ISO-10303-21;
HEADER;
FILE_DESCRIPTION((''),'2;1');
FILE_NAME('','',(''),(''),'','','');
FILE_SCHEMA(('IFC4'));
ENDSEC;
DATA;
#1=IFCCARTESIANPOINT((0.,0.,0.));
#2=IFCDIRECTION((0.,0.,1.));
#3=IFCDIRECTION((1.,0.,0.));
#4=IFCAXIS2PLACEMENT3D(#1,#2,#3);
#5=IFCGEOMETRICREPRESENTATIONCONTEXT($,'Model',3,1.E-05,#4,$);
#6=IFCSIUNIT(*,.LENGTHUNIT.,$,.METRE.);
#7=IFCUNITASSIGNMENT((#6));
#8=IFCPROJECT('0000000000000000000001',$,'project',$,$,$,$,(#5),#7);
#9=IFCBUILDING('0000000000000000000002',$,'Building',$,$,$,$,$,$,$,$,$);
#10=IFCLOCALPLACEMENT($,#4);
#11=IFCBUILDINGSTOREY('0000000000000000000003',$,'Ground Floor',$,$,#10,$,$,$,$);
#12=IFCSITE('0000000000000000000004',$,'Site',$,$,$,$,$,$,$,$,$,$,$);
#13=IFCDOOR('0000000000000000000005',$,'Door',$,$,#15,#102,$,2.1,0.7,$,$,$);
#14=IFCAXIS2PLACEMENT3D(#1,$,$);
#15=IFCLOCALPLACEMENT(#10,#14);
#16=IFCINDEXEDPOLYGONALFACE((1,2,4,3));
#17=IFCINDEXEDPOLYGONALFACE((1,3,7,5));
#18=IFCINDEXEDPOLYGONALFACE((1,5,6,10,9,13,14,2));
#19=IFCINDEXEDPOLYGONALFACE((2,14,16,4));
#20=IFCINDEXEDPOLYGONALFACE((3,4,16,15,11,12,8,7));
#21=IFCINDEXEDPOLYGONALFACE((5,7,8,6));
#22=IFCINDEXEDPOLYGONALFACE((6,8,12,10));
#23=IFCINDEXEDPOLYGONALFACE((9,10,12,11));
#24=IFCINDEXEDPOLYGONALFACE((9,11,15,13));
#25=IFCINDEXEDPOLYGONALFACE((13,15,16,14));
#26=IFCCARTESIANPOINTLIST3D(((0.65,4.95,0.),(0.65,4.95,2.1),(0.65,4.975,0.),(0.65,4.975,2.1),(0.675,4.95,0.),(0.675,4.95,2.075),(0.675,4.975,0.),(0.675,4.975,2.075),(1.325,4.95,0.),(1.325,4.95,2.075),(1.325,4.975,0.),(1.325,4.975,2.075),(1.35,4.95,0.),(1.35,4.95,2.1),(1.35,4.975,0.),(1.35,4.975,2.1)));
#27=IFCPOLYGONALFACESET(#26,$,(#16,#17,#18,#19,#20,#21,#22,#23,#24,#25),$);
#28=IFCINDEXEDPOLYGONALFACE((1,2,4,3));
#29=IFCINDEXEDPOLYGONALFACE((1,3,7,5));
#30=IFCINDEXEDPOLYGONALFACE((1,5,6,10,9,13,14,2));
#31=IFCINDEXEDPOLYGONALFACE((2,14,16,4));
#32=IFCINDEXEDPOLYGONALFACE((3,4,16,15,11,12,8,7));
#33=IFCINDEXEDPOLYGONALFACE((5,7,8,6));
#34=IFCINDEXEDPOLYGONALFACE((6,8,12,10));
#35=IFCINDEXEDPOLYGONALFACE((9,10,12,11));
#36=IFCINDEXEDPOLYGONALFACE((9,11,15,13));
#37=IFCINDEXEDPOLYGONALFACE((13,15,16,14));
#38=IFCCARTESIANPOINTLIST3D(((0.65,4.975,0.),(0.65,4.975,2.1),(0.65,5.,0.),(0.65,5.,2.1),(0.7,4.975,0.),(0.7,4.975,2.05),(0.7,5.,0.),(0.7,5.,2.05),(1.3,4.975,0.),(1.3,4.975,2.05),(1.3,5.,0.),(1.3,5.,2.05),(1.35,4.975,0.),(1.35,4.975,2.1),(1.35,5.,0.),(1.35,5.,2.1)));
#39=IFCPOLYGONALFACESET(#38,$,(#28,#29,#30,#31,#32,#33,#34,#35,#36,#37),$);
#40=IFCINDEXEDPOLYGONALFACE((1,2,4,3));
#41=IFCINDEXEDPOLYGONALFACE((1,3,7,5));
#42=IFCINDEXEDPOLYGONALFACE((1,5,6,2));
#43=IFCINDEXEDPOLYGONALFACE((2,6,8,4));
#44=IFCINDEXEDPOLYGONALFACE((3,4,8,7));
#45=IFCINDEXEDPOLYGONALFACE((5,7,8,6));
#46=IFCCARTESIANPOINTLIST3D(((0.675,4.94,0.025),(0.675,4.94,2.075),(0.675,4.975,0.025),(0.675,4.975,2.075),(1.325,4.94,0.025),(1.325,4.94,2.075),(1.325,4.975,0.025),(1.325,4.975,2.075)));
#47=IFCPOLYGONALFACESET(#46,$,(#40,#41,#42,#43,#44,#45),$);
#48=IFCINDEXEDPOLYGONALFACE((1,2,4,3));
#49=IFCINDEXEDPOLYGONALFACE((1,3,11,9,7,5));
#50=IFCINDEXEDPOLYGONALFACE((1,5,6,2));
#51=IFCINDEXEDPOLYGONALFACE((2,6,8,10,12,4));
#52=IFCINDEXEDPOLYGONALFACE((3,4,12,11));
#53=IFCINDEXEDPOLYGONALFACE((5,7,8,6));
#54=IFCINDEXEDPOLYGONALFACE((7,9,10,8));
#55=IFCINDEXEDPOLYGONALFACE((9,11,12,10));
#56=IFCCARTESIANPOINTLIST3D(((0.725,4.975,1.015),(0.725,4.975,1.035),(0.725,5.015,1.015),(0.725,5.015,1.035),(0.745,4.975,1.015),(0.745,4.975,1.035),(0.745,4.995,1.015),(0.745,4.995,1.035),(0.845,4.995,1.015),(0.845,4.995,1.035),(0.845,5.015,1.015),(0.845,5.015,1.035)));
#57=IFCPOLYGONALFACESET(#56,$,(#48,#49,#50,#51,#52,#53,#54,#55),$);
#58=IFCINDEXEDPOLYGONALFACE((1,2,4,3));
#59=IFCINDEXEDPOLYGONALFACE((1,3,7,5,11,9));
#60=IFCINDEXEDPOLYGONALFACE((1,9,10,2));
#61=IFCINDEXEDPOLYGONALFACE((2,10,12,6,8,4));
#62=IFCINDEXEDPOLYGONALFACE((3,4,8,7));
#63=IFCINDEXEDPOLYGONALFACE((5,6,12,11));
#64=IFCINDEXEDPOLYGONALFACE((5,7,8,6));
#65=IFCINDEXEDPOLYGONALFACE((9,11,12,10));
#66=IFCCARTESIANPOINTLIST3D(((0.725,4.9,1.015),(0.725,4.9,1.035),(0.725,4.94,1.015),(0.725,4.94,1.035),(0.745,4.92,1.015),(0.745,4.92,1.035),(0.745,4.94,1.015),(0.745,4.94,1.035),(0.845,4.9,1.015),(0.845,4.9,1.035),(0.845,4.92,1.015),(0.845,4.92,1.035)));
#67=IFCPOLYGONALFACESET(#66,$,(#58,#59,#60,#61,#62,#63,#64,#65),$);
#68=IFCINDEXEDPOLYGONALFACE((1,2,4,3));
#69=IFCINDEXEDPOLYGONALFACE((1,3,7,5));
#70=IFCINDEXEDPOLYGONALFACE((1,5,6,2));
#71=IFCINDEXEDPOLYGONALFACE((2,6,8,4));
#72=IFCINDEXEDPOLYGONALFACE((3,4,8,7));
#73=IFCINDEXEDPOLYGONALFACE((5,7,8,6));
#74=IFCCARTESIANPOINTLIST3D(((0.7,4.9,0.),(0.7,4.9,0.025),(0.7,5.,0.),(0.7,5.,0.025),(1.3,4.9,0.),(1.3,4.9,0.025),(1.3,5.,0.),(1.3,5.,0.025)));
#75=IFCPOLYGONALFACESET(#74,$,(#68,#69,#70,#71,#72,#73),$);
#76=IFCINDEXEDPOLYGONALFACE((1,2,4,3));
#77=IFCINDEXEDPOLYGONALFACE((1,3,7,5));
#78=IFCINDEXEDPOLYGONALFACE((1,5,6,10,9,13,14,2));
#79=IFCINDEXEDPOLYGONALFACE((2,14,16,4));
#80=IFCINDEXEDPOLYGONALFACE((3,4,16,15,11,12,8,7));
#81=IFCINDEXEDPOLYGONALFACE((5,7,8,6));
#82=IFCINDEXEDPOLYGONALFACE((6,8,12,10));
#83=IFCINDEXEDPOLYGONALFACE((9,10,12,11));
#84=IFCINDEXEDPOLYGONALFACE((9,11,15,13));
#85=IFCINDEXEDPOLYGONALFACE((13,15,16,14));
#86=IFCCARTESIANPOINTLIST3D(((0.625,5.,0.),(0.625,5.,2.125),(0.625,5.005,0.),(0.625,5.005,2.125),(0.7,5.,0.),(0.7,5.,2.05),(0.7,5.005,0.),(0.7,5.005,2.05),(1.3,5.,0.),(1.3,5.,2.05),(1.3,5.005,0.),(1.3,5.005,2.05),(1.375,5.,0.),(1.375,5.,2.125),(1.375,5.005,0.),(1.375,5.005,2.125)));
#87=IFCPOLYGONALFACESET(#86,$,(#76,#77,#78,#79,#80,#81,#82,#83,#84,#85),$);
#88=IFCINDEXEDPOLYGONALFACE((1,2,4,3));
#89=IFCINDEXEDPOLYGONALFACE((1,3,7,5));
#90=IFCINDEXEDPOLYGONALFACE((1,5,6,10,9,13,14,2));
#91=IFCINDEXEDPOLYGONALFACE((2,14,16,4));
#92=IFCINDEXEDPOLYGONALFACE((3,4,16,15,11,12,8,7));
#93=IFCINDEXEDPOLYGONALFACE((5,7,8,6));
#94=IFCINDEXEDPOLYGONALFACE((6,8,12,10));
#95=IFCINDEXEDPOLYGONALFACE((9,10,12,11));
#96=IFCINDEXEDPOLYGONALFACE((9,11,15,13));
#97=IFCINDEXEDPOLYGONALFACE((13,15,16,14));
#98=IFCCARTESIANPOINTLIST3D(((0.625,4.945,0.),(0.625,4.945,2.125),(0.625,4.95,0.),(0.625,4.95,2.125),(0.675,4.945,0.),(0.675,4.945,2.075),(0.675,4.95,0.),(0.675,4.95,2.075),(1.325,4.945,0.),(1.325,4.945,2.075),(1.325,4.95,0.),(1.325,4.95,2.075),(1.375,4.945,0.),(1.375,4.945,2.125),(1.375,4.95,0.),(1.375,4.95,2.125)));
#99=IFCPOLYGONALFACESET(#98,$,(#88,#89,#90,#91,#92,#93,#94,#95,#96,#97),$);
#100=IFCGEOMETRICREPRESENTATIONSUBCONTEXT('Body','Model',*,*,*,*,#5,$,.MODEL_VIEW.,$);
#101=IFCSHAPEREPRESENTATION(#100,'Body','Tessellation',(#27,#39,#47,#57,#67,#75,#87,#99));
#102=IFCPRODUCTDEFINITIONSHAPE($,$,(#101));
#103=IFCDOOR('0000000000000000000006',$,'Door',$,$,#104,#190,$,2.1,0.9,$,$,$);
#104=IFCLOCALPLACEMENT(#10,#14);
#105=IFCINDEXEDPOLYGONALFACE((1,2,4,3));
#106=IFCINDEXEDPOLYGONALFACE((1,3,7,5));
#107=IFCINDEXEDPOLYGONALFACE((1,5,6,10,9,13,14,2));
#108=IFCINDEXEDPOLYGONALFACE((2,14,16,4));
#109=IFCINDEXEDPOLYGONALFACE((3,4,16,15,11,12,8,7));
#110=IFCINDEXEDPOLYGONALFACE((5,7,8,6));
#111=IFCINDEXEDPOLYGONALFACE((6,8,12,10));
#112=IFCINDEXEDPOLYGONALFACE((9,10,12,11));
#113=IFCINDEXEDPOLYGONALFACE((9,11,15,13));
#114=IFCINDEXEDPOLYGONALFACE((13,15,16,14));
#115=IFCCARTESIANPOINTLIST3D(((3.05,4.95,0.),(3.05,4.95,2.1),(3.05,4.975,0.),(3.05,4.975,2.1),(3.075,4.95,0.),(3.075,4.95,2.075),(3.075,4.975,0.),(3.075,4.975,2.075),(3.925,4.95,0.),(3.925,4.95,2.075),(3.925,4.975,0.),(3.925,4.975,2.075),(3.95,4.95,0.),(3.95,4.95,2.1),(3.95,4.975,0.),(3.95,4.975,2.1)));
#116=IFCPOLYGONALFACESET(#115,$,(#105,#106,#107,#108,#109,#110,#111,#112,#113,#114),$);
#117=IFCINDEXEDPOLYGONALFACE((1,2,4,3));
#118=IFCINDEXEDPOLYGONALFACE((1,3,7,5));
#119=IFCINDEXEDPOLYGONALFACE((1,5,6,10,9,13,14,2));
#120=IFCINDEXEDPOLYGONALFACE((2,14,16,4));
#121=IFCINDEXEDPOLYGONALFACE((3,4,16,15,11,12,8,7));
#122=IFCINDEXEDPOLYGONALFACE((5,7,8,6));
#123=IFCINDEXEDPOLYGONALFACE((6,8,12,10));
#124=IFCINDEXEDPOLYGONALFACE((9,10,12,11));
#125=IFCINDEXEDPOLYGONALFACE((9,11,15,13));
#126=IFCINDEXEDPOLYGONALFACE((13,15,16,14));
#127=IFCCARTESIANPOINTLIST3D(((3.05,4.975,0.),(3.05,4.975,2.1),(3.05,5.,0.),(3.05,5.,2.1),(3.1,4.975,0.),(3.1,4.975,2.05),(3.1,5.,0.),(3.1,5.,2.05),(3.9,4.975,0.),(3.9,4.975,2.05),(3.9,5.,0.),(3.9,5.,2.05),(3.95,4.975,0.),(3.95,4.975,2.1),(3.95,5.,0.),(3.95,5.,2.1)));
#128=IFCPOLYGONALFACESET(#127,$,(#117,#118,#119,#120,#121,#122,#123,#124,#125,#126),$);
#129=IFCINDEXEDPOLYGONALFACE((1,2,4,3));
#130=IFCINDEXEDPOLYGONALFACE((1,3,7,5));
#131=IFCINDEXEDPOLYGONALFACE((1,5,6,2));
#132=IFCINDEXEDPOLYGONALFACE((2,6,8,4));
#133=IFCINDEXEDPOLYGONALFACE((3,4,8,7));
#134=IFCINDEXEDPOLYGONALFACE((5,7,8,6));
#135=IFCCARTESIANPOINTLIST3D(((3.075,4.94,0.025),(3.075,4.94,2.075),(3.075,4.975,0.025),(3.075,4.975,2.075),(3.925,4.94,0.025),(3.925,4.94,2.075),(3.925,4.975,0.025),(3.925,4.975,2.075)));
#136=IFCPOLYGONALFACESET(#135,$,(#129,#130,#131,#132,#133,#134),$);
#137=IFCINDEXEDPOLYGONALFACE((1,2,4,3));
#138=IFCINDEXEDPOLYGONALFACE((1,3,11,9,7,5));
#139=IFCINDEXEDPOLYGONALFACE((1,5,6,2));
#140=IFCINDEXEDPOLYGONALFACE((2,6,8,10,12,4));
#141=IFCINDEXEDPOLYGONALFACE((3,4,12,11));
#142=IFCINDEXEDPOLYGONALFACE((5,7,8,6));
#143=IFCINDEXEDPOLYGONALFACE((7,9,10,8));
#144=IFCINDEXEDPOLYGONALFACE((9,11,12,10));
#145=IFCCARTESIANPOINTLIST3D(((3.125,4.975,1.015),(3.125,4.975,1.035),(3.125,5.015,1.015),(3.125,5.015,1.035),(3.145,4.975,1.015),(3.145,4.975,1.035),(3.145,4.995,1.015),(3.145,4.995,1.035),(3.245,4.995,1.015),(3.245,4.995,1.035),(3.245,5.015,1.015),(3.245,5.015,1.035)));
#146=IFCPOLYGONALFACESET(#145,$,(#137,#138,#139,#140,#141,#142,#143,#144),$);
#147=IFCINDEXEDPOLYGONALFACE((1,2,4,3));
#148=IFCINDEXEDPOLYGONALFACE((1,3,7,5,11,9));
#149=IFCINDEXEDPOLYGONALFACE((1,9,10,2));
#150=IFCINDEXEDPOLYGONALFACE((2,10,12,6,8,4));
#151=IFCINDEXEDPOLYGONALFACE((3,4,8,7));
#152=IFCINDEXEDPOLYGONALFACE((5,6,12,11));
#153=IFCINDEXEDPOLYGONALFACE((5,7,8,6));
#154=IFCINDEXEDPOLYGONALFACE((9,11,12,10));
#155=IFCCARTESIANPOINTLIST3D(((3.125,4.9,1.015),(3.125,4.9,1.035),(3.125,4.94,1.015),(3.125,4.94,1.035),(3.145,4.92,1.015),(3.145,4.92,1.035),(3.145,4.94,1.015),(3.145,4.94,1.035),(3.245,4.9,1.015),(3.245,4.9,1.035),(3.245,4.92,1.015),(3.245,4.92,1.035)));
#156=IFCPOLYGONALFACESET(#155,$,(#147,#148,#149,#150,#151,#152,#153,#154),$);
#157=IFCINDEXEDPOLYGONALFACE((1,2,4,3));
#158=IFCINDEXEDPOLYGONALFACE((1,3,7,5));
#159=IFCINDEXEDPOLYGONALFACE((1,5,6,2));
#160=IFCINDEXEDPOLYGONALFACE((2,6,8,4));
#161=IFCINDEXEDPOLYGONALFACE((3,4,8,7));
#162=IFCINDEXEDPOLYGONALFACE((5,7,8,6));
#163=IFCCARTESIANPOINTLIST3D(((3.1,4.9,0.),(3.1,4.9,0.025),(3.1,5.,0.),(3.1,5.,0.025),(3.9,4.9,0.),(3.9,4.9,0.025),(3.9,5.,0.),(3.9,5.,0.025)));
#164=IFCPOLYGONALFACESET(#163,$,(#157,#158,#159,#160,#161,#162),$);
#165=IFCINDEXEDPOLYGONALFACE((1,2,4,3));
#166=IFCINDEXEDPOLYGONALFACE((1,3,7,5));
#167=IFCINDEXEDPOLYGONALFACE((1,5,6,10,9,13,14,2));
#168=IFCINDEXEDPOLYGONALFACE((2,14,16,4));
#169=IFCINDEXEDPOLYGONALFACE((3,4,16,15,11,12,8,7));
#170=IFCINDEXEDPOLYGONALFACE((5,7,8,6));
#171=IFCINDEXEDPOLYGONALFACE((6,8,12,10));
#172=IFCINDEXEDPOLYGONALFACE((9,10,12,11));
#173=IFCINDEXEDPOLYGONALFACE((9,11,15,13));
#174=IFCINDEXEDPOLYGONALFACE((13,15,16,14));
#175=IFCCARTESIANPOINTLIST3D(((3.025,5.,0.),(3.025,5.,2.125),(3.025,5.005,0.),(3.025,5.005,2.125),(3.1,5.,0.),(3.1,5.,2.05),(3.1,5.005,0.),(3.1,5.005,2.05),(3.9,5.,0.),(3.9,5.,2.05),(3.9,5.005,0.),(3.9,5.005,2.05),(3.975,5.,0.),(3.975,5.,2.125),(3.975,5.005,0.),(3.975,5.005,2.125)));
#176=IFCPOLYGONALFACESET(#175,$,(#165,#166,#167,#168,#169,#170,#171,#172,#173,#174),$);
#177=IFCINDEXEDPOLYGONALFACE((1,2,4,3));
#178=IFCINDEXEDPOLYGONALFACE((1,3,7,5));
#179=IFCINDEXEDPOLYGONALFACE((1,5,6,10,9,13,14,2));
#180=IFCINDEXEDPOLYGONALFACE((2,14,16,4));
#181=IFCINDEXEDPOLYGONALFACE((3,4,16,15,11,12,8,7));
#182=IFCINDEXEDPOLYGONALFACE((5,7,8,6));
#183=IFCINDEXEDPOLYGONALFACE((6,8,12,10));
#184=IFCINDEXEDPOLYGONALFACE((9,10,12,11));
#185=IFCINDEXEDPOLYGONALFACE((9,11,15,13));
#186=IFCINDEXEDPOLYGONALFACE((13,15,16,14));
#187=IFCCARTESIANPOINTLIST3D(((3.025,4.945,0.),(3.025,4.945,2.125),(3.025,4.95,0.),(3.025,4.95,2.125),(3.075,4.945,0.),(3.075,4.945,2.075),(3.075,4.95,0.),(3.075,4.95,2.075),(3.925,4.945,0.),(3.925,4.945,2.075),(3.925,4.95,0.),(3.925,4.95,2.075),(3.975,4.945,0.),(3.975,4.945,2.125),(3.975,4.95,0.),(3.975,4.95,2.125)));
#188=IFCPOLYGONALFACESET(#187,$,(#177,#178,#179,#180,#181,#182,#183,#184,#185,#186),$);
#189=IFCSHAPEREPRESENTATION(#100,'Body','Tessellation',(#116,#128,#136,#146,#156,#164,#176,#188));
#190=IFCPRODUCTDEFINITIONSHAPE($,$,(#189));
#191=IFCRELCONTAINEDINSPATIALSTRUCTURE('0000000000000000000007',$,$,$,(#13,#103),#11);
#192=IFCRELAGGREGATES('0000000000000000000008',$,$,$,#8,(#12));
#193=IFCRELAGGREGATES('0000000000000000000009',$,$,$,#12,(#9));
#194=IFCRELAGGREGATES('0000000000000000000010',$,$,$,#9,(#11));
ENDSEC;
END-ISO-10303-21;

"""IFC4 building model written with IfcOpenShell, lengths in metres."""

from ifc_helpers import new_model, si_unit, frame, origin_with_axes, place, context, subcontext, project, spatial, line, indexed_curve, outline, extrude, element, save


model = new_model("IFC4")

# Units and contexts
model_context = context("Model", 3, precision=1e-05, world=origin_with_axes())
body_context = subcontext(model_context, "Body", "Model", "MODEL_VIEW")
ifc_project = project(units=[si_unit("LENGTHUNIT", "METRE")], contexts=[model_context])

# Site, building, storey
site = spatial("IfcSite", under=ifc_project, Name="Site")
building = spatial("IfcBuilding", under=site, Name="Building")
storey_placement = place(None, origin_with_axes())
storey = spatial("IfcBuildingStorey", under=building, at=storey_placement, Name="Ground Floor")

# Doors
door_1_placement = place(storey_placement, frame((1.35, 5.0, 0.0), z_axis=(0.0, 0.0, 1.0), x_axis=(-1.0, 0.0, 0.0)))
element("IfcDoor", 1, at=door_1_placement, inside=storey, Name="Door", OverallHeight=2.1, OverallWidth=0.7, context=body_context, shape_type="SweptSolid", body=[
    extrude(outline(indexed_curve([(0.0, 0.0), (0.0, 2.1), (0.7, 2.1), (0.7, 0.0), (0.675, 0.0), (0.675, 2.075), (0.025, 2.075), (0.025, 0.0)], segments=[line(1, 2, 3, 4, 5, 6, 7, 8, 1)])), frame((0.0, 0.025, 0.0), z_axis=(0.0, -1.0, 0.0), x_axis=(1.0, 0.0, 0.0)), (0.0, 0.0, -1.0), 0.025),
    extrude(outline(indexed_curve([(0.0, 0.0), (0.0, 2.1), (0.7, 2.1), (0.7, 0.0), (0.65, 0.0), (0.65, 2.05), (0.05, 2.05), (0.05, 0.0)], segments=[line(1, 2, 3, 4, 5, 6, 7, 8, 1)])), frame((0.0, 0.0, 0.0), z_axis=(0.0, -1.0, 0.0), x_axis=(1.0, 0.0, 0.0)), (0.0, 0.0, -1.0), 0.025),
    extrude(outline(indexed_curve([(0.0, 0.0), (0.65, 0.0), (0.65, 0.035), (0.0, 0.035)], segments=[line(1, 2, 3, 4, 1)])), frame((0.025, 0.025, 0.025), z_axis=(0.0, 0.0, 1.0), x_axis=(1.0, 0.0, 0.0)), (0.0, 0.0, 1.0), 2.05),
    extrude(outline(indexed_curve([(0.0, 0.0), (0.0, -0.04), (-0.12, -0.04), (-0.12, -0.02), (-0.02, -0.02), (-0.02, 0.0)], segments=[line(1, 2, 3, 4, 5, 6, 1)])), frame((0.625, 0.025, 1.015), z_axis=(0.0, 0.0, 1.0), x_axis=(1.0, 0.0, 0.0)), (0.0, 0.0, 1.0), 0.02),
    extrude(outline(indexed_curve([(0.0, 0.0), (0.0, 0.04), (-0.12, 0.04), (-0.12, 0.02), (-0.02, 0.02), (-0.02, 0.0)], segments=[line(1, 2, 3, 4, 5, 6, 1)])), frame((0.625, 0.06, 1.015), z_axis=(0.0, 0.0, 1.0), x_axis=(1.0, 0.0, 0.0)), (0.0, 0.0, 1.0), 0.02),
    extrude(outline(indexed_curve([(0.0, 0.0), (0.6, 0.0), (0.6, 0.1), (0.0, 0.1)], segments=[line(1, 2, 3, 4, 1)])), frame((0.05, 0.0, 0.0), z_axis=(0.0, 0.0, 1.0), x_axis=(1.0, 0.0, 0.0)), (0.0, 0.0, 1.0), 0.025),
    extrude(outline(indexed_curve([(0.0, 0.0), (0.0, 2.125), (0.75, 2.125), (0.75, 0.0), (0.675, 0.0), (0.675, 2.05), (0.075, 2.05), (0.075, 0.0)], segments=[line(1, 2, 3, 4, 5, 6, 7, 8, 1)])), frame((-0.025, -0.005, 0.0), z_axis=(0.0, -1.0, 0.0), x_axis=(1.0, 0.0, 0.0)), (0.0, 0.0, -1.0), 0.005),
    extrude(outline(indexed_curve([(0.0, 0.0), (0.0, 2.125), (0.75, 2.125), (0.75, 0.0), (0.7, 0.0), (0.7, 2.075), (0.05, 2.075), (0.05, 0.0)], segments=[line(1, 2, 3, 4, 5, 6, 7, 8, 1)])), frame((-0.025, 0.05, 0.0), z_axis=(0.0, -1.0, 0.0), x_axis=(1.0, 0.0, 0.0)), (0.0, 0.0, -1.0), 0.005),
])
door_2_placement = place(storey_placement, frame((3.95, 5.0, 0.0), z_axis=(0.0, 0.0, 1.0), x_axis=(-1.0, 0.0, 0.0)))
element("IfcDoor", 2, at=door_2_placement, inside=storey, Name="Door", OverallHeight=2.1, OverallWidth=0.9, context=body_context, shape_type="SweptSolid", body=[
    extrude(outline(indexed_curve([(0.0, 0.0), (0.0, 2.1), (0.9, 2.1), (0.9, 0.0), (0.875, 0.0), (0.875, 2.075), (0.025, 2.075), (0.025, 0.0)], segments=[line(1, 2, 3, 4, 5, 6, 7, 8, 1)])), frame((0.0, 0.025, 0.0), z_axis=(0.0, -1.0, 0.0), x_axis=(1.0, 0.0, 0.0)), (0.0, 0.0, -1.0), 0.025),
    extrude(outline(indexed_curve([(0.0, 0.0), (0.0, 2.1), (0.9, 2.1), (0.9, 0.0), (0.85, 0.0), (0.85, 2.05), (0.05, 2.05), (0.05, 0.0)], segments=[line(1, 2, 3, 4, 5, 6, 7, 8, 1)])), frame((0.0, 0.0, 0.0), z_axis=(0.0, -1.0, 0.0), x_axis=(1.0, 0.0, 0.0)), (0.0, 0.0, -1.0), 0.025),
    extrude(outline(indexed_curve([(0.0, 0.0), (0.85, 0.0), (0.85, 0.035), (0.0, 0.035)], segments=[line(1, 2, 3, 4, 1)])), frame((0.025, 0.025, 0.025), z_axis=(0.0, 0.0, 1.0), x_axis=(1.0, 0.0, 0.0)), (0.0, 0.0, 1.0), 2.05),
    extrude(outline(indexed_curve([(0.0, 0.0), (0.0, -0.04), (-0.12, -0.04), (-0.12, -0.02), (-0.02, -0.02), (-0.02, 0.0)], segments=[line(1, 2, 3, 4, 5, 6, 1)])), frame((0.825, 0.025, 1.015), z_axis=(0.0, 0.0, 1.0), x_axis=(1.0, 0.0, 0.0)), (0.0, 0.0, 1.0), 0.02),
    extrude(outline(indexed_curve([(0.0, 0.0), (0.0, 0.04), (-0.12, 0.04), (-0.12, 0.02), (-0.02, 0.02), (-0.02, 0.0)], segments=[line(1, 2, 3, 4, 5, 6, 1)])), frame((0.825, 0.06, 1.015), z_axis=(0.0, 0.0, 1.0), x_axis=(1.0, 0.0, 0.0)), (0.0, 0.0, 1.0), 0.02),
    extrude(outline(indexed_curve([(0.0, 0.0), (0.8, 0.0), (0.8, 0.1), (0.0, 0.1)], segments=[line(1, 2, 3, 4, 1)])), frame((0.05, 0.0, 0.0), z_axis=(0.0, 0.0, 1.0), x_axis=(1.0, 0.0, 0.0)), (0.0, 0.0, 1.0), 0.025),
    extrude(outline(indexed_curve([(0.0, 0.0), (0.0, 2.125), (0.95, 2.125), (0.95, 0.0), (0.875, 0.0), (0.875, 2.05), (0.075, 2.05), (0.075, 0.0)], segments=[line(1, 2, 3, 4, 5, 6, 7, 8, 1)])), frame((-0.025, -0.005, 0.0), z_axis=(0.0, -1.0, 0.0), x_axis=(1.0, 0.0, 0.0)), (0.0, 0.0, -1.0), 0.005),
    extrude(outline(indexed_curve([(0.0, 0.0), (0.0, 2.125), (0.95, 2.125), (0.95, 0.0), (0.9, 0.0), (0.9, 2.075), (0.05, 2.075), (0.05, 0.0)], segments=[line(1, 2, 3, 4, 5, 6, 7, 8, 1)])), frame((-0.025, 0.05, 0.0), z_axis=(0.0, -1.0, 0.0), x_axis=(1.0, 0.0, 0.0)), (0.0, 0.0, -1.0), 0.005),
])

save(model, "model.ifc")
